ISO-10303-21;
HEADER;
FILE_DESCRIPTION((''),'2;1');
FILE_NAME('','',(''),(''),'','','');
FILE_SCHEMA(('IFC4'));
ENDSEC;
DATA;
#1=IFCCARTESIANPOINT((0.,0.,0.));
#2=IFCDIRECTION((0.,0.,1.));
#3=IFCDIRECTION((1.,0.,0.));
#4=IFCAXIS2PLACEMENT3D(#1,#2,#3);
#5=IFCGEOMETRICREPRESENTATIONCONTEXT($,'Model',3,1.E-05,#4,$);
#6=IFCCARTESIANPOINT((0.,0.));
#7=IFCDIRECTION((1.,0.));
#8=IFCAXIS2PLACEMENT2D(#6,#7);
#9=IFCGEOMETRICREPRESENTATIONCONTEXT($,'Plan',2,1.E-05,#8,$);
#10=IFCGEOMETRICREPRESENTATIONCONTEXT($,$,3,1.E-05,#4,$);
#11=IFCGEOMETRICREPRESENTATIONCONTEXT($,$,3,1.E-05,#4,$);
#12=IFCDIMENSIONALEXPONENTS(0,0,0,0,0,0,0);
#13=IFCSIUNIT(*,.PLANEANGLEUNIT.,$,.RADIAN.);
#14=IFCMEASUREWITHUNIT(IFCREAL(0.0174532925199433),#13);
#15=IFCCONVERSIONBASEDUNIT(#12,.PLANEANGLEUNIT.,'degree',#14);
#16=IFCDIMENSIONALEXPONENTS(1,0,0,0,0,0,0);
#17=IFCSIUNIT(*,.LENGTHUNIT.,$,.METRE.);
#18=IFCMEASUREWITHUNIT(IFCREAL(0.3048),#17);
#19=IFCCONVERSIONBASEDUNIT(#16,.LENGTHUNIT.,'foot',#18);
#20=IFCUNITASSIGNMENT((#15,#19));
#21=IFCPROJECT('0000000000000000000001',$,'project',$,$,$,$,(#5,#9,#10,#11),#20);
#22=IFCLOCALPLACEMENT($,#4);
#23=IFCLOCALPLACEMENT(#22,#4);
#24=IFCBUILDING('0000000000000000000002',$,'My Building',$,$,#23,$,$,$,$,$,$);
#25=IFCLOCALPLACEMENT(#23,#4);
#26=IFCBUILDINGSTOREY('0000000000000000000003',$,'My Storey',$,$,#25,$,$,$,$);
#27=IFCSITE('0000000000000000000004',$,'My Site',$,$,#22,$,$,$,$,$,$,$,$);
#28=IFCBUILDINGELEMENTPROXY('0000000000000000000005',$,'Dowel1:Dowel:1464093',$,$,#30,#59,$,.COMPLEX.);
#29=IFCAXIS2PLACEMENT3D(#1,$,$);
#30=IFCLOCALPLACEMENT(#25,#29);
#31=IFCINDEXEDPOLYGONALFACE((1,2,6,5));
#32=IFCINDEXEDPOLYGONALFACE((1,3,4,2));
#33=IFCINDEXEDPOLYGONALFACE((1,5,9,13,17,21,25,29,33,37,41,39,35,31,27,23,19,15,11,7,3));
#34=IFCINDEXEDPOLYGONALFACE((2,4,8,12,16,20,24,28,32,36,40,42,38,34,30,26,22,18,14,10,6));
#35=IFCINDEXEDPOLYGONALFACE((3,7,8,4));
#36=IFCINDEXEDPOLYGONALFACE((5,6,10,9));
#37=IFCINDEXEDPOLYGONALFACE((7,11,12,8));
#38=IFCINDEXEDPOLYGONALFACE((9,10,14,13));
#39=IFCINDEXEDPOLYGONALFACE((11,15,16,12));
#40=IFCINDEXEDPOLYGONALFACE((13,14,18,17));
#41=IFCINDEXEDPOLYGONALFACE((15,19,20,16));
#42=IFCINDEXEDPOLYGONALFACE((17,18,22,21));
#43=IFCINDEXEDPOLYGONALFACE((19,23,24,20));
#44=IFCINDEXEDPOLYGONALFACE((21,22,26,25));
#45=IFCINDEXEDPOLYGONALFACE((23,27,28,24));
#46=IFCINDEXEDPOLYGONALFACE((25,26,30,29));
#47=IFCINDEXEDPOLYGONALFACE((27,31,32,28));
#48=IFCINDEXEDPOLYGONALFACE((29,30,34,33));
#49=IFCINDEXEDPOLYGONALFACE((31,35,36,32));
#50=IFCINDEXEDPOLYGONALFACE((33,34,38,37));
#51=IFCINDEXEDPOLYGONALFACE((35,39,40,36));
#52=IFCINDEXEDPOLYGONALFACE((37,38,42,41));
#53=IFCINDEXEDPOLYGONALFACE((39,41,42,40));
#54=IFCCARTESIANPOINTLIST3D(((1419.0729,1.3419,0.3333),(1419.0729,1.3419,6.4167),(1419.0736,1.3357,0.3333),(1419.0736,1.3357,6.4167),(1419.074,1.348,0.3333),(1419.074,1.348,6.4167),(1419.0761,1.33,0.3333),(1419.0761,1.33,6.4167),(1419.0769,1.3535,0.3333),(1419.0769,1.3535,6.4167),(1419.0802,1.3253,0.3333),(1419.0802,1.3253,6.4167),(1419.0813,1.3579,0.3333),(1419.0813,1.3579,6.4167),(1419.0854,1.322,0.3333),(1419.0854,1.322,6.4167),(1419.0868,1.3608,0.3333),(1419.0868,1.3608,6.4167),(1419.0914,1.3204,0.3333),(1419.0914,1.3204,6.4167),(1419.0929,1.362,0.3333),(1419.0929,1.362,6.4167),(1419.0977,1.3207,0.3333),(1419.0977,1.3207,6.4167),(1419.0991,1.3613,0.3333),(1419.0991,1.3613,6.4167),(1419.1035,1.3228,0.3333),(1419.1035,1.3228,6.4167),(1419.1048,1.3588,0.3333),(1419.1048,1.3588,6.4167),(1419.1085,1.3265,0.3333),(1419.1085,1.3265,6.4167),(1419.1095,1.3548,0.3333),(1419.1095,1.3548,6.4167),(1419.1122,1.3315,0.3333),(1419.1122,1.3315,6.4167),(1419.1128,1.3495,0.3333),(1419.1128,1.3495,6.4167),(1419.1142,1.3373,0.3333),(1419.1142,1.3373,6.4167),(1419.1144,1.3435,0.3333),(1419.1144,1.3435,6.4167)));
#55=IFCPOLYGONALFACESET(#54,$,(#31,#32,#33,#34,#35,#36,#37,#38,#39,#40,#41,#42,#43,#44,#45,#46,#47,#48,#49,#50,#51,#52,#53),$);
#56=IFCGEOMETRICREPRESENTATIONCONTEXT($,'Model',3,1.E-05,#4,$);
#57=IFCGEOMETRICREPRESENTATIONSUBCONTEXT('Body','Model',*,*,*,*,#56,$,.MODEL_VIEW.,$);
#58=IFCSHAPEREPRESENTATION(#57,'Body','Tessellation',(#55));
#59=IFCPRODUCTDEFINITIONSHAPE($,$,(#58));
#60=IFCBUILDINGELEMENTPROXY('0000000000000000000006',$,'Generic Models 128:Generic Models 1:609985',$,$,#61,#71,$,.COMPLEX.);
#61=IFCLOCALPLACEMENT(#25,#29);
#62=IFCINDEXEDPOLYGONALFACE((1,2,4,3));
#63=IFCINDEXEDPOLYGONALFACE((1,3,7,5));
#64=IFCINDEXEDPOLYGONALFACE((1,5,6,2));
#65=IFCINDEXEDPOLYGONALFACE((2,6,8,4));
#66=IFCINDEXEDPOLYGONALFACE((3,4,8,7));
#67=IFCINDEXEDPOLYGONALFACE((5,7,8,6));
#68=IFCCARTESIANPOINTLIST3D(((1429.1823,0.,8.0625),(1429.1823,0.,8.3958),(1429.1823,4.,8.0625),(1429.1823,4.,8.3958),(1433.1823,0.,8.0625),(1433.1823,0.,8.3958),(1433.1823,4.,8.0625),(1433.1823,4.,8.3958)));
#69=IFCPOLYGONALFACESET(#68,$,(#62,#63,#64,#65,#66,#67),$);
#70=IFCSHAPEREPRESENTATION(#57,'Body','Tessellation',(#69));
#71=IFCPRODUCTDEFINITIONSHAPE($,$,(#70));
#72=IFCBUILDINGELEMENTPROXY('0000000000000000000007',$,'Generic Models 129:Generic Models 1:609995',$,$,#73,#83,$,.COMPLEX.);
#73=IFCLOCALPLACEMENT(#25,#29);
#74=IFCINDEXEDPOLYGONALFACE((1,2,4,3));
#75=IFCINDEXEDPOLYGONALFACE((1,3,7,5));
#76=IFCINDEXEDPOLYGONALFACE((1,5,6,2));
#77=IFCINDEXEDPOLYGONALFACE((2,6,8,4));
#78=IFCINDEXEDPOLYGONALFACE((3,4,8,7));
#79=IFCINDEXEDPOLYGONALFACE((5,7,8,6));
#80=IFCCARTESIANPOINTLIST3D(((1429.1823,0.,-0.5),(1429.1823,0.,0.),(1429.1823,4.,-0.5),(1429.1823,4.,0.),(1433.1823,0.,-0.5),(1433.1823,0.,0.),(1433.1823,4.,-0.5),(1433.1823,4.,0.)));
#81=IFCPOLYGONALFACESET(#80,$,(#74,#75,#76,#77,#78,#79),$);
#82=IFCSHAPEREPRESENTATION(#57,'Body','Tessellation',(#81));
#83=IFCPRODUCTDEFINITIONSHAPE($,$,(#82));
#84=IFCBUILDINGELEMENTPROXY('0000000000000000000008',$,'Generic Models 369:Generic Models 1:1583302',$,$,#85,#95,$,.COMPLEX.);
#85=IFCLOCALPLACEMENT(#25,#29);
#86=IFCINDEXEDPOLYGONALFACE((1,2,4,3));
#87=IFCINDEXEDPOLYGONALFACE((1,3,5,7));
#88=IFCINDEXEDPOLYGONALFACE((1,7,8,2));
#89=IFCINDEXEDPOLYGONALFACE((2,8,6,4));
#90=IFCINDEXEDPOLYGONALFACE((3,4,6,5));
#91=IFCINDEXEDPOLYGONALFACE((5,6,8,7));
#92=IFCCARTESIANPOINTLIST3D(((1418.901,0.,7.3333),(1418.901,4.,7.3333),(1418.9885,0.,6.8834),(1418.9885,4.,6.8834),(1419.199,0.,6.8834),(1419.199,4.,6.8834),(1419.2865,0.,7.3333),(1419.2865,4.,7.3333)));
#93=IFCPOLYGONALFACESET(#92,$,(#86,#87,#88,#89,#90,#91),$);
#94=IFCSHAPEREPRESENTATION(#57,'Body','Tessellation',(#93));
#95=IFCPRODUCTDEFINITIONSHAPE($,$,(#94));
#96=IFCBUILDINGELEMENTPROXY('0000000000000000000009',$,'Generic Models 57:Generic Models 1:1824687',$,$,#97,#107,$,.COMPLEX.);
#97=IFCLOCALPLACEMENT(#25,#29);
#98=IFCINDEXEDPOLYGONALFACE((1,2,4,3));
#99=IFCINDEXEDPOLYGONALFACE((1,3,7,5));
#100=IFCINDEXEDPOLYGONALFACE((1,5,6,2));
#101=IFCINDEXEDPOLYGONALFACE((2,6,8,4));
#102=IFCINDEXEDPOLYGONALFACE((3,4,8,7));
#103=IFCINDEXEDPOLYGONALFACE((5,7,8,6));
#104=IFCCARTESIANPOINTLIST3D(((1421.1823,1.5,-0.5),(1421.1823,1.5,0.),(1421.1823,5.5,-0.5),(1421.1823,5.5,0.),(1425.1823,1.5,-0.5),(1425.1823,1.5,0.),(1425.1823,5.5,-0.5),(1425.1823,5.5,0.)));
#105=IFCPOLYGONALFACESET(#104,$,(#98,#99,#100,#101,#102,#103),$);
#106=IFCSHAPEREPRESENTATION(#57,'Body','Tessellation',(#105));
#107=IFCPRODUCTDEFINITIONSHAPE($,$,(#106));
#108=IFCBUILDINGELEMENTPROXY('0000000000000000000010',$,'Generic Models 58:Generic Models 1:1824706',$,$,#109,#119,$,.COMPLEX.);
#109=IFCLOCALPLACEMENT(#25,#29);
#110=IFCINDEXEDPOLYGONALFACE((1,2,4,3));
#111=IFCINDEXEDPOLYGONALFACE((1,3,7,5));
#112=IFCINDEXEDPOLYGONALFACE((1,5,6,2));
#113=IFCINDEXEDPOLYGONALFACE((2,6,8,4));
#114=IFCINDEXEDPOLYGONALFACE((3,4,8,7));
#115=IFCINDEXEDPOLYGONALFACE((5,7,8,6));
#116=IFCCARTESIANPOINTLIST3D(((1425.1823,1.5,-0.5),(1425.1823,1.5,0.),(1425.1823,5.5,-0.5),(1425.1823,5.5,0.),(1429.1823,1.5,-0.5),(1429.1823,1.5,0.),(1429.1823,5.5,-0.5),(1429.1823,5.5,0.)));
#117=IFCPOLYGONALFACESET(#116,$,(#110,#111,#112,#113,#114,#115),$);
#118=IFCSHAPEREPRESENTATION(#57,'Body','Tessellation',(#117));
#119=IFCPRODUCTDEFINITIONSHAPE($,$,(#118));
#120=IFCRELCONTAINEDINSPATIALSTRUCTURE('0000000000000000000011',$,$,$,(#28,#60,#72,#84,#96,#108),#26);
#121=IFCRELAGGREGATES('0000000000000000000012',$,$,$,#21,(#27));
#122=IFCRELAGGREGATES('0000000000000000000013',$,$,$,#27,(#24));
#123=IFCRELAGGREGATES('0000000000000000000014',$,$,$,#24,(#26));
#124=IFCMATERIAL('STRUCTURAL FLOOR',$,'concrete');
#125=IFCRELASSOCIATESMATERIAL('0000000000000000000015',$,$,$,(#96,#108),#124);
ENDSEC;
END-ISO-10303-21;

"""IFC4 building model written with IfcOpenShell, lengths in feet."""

from ifc_helpers import new_model, entity, si_unit, converted_unit, frame, origin_with_axes, origin_2d_with_axis, place, context, subcontext, project, spatial, polyline, line, indexed_curve, circle, outline, extrude, material, element, save


model = new_model("IFC4")

# Units and contexts
model_context_1 = context("Model", 3, precision=1e-05, world=origin_with_axes())
plan_context = context("Plan", 2, precision=1e-05, world=origin_2d_with_axis())
model_context_2 = context("Model", 3, precision=1e-05, world=origin_with_axes())
context_of_model_1 = context(None, 3, precision=1e-05, world=origin_with_axes())
context_of_model_2 = context(None, 3, precision=1e-05, world=origin_with_axes())
body_context_1 = subcontext(model_context_2, "Body", "Model", "MODEL_VIEW")
ifc_project = project(units=[converted_unit("PLANEANGLEUNIT", "degree", entity("IfcReal", 0.0174532925199433), si_unit("PLANEANGLEUNIT", "RADIAN"), dimensions=[0, 0, 0, 0, 0, 0, 0]), converted_unit("LENGTHUNIT", "foot", entity("IfcReal", 0.3048), si_unit("LENGTHUNIT", "METRE"), dimensions=[1, 0, 0, 0, 0, 0, 0])], contexts=[model_context_1, plan_context, context_of_model_1, context_of_model_2])

# Site, building, storey
site_placement = place(None, origin_with_axes())
site = spatial("IfcSite", under=ifc_project, at=site_placement, Name="My Site")
building_placement = place(site_placement, origin_with_axes())
building = spatial("IfcBuilding", under=site, at=building_placement, Name="My Building")
storey_placement = place(building_placement, origin_with_axes())
storey = spatial("IfcBuildingStorey", under=building, at=storey_placement, Name="My Storey")

# Building element proxies
proxy_1_placement = place(storey_placement, frame((1419.0729, 1.3203, 0.3333), z_axis=(0.0, 0.0, 1.0), x_axis=(0.0, 1.0, 0.0)))
element("IfcBuildingElementProxy", 1, at=proxy_1_placement, inside=storey, Name="Dowel1:Dowel:1464093", PredefinedType="COMPLEX", context=body_context_1, shape_type="SweptSolid", body=[
    extrude(circle(Radius=0.0208, at=origin_2d_with_axis()), frame((0.0208, -0.0208, 0.0), z_axis=(0.0, 0.0, -1.0), x_axis=(-0.464723, -0.885456, 0.0)), (0.0, 0.0, -1.0), 6.0833),
])
proxy_2_placement = place(storey_placement, frame((1429.1823, 4.0, 8.0625), z_axis=(0.0, -1.0, 0.0), x_axis=(0.0, 0.0, 1.0)))
element("IfcBuildingElementProxy", 2, at=proxy_2_placement, inside=storey, Name="Generic Models 128:Generic Models 1:609985", PredefinedType="COMPLEX", context=body_context_1, shape_type="SweptSolid", body=[
    extrude(outline(polyline([(-0.1667, -2.0), (0.1667, -2.0), (0.1667, 2.0), (-0.1667, 2.0), (-0.1667, -2.0)])), frame((0.1667, -2.0, 0.0), z_axis=(0.0, 0.0, -1.0), x_axis=(-1.0, 0.0, 0.0)), (0.0, 0.0, -1.0), 4.0),
])
proxy_3_placement = place(storey_placement, frame((1429.1823, 4.0, -0.5), z_axis=(0.0, -1.0, 0.0), x_axis=(0.0, 0.0, 1.0)))
element("IfcBuildingElementProxy", 3, at=proxy_3_placement, inside=storey, Name="Generic Models 129:Generic Models 1:609995", PredefinedType="COMPLEX", context=body_context_1, shape_type="SweptSolid", body=[
    extrude(outline(polyline([(-0.25, -2.0), (0.25, -2.0), (0.25, 2.0), (-0.25, 2.0), (-0.25, -2.0)])), frame((0.25, -2.0, 0.0), z_axis=(0.0, 0.0, -1.0), x_axis=(-1.0, 0.0, 0.0)), (0.0, 0.0, -1.0), 4.0),
])
proxy_4_placement = place(storey_placement, frame((1419.2865, 0.0, 6.8834), z_axis=(0.0, 1.0, 0.0), x_axis=(0.0, 0.0, 1.0)))
element("IfcBuildingElementProxy", 4, at=proxy_4_placement, inside=storey, Name="Generic Models 369:Generic Models 1:1583302", PredefinedType="COMPLEX", context=body_context_1, shape_type="SweptSolid", body=[
    extrude(outline(indexed_curve([(-0.1053, 0.225), (0.1053, 0.225), (0.1927, -0.225), (-0.1927, -0.225)], segments=[line(4, 1), line(1, 2), line(2, 3), line(3, 4)], self_intersect=False)), frame((0.225, -0.1927, 4.0), z_axis=(0.0, 0.0, -1.0), x_axis=(0.0, -1.0, 0.0)), (0.0, 0.0, 1.0), 4.0),
])
ifc_material = material(Name="STRUCTURAL FLOOR", Category="concrete")
for number, where, z_axis, x_axis, name in (
    (5, (1421.1823, 5.5, -0.5), (0.0, -1.0, 0.0), (0.0, 0.0, 1.0), "Generic Models 57:Generic Models 1:1824687"),
    (6, (1425.1823, 5.5, -0.5), (0.0, -1.0, 0.0), (0.0, 0.0, 1.0), "Generic Models 58:Generic Models 1:1824706"),
):
    element("IfcBuildingElementProxy", number, at=place(storey_placement, frame(where, z_axis=z_axis, x_axis=x_axis)), inside=storey, material=ifc_material, Name=name, PredefinedType="COMPLEX", context=body_context_1, shape_type="SweptSolid", body=[
        extrude(outline(polyline([(-0.25, -2.0), (0.25, -2.0), (0.25, 2.0), (-0.25, 2.0), (-0.25, -2.0)])), frame((0.25, -2.0, 0.0), z_axis=(0.0, 0.0, -1.0), x_axis=(1.0, 0.0, 0.0)), (0.0, 0.0, -1.0), 4.0),
    ])

save(model, "model.ifc")
